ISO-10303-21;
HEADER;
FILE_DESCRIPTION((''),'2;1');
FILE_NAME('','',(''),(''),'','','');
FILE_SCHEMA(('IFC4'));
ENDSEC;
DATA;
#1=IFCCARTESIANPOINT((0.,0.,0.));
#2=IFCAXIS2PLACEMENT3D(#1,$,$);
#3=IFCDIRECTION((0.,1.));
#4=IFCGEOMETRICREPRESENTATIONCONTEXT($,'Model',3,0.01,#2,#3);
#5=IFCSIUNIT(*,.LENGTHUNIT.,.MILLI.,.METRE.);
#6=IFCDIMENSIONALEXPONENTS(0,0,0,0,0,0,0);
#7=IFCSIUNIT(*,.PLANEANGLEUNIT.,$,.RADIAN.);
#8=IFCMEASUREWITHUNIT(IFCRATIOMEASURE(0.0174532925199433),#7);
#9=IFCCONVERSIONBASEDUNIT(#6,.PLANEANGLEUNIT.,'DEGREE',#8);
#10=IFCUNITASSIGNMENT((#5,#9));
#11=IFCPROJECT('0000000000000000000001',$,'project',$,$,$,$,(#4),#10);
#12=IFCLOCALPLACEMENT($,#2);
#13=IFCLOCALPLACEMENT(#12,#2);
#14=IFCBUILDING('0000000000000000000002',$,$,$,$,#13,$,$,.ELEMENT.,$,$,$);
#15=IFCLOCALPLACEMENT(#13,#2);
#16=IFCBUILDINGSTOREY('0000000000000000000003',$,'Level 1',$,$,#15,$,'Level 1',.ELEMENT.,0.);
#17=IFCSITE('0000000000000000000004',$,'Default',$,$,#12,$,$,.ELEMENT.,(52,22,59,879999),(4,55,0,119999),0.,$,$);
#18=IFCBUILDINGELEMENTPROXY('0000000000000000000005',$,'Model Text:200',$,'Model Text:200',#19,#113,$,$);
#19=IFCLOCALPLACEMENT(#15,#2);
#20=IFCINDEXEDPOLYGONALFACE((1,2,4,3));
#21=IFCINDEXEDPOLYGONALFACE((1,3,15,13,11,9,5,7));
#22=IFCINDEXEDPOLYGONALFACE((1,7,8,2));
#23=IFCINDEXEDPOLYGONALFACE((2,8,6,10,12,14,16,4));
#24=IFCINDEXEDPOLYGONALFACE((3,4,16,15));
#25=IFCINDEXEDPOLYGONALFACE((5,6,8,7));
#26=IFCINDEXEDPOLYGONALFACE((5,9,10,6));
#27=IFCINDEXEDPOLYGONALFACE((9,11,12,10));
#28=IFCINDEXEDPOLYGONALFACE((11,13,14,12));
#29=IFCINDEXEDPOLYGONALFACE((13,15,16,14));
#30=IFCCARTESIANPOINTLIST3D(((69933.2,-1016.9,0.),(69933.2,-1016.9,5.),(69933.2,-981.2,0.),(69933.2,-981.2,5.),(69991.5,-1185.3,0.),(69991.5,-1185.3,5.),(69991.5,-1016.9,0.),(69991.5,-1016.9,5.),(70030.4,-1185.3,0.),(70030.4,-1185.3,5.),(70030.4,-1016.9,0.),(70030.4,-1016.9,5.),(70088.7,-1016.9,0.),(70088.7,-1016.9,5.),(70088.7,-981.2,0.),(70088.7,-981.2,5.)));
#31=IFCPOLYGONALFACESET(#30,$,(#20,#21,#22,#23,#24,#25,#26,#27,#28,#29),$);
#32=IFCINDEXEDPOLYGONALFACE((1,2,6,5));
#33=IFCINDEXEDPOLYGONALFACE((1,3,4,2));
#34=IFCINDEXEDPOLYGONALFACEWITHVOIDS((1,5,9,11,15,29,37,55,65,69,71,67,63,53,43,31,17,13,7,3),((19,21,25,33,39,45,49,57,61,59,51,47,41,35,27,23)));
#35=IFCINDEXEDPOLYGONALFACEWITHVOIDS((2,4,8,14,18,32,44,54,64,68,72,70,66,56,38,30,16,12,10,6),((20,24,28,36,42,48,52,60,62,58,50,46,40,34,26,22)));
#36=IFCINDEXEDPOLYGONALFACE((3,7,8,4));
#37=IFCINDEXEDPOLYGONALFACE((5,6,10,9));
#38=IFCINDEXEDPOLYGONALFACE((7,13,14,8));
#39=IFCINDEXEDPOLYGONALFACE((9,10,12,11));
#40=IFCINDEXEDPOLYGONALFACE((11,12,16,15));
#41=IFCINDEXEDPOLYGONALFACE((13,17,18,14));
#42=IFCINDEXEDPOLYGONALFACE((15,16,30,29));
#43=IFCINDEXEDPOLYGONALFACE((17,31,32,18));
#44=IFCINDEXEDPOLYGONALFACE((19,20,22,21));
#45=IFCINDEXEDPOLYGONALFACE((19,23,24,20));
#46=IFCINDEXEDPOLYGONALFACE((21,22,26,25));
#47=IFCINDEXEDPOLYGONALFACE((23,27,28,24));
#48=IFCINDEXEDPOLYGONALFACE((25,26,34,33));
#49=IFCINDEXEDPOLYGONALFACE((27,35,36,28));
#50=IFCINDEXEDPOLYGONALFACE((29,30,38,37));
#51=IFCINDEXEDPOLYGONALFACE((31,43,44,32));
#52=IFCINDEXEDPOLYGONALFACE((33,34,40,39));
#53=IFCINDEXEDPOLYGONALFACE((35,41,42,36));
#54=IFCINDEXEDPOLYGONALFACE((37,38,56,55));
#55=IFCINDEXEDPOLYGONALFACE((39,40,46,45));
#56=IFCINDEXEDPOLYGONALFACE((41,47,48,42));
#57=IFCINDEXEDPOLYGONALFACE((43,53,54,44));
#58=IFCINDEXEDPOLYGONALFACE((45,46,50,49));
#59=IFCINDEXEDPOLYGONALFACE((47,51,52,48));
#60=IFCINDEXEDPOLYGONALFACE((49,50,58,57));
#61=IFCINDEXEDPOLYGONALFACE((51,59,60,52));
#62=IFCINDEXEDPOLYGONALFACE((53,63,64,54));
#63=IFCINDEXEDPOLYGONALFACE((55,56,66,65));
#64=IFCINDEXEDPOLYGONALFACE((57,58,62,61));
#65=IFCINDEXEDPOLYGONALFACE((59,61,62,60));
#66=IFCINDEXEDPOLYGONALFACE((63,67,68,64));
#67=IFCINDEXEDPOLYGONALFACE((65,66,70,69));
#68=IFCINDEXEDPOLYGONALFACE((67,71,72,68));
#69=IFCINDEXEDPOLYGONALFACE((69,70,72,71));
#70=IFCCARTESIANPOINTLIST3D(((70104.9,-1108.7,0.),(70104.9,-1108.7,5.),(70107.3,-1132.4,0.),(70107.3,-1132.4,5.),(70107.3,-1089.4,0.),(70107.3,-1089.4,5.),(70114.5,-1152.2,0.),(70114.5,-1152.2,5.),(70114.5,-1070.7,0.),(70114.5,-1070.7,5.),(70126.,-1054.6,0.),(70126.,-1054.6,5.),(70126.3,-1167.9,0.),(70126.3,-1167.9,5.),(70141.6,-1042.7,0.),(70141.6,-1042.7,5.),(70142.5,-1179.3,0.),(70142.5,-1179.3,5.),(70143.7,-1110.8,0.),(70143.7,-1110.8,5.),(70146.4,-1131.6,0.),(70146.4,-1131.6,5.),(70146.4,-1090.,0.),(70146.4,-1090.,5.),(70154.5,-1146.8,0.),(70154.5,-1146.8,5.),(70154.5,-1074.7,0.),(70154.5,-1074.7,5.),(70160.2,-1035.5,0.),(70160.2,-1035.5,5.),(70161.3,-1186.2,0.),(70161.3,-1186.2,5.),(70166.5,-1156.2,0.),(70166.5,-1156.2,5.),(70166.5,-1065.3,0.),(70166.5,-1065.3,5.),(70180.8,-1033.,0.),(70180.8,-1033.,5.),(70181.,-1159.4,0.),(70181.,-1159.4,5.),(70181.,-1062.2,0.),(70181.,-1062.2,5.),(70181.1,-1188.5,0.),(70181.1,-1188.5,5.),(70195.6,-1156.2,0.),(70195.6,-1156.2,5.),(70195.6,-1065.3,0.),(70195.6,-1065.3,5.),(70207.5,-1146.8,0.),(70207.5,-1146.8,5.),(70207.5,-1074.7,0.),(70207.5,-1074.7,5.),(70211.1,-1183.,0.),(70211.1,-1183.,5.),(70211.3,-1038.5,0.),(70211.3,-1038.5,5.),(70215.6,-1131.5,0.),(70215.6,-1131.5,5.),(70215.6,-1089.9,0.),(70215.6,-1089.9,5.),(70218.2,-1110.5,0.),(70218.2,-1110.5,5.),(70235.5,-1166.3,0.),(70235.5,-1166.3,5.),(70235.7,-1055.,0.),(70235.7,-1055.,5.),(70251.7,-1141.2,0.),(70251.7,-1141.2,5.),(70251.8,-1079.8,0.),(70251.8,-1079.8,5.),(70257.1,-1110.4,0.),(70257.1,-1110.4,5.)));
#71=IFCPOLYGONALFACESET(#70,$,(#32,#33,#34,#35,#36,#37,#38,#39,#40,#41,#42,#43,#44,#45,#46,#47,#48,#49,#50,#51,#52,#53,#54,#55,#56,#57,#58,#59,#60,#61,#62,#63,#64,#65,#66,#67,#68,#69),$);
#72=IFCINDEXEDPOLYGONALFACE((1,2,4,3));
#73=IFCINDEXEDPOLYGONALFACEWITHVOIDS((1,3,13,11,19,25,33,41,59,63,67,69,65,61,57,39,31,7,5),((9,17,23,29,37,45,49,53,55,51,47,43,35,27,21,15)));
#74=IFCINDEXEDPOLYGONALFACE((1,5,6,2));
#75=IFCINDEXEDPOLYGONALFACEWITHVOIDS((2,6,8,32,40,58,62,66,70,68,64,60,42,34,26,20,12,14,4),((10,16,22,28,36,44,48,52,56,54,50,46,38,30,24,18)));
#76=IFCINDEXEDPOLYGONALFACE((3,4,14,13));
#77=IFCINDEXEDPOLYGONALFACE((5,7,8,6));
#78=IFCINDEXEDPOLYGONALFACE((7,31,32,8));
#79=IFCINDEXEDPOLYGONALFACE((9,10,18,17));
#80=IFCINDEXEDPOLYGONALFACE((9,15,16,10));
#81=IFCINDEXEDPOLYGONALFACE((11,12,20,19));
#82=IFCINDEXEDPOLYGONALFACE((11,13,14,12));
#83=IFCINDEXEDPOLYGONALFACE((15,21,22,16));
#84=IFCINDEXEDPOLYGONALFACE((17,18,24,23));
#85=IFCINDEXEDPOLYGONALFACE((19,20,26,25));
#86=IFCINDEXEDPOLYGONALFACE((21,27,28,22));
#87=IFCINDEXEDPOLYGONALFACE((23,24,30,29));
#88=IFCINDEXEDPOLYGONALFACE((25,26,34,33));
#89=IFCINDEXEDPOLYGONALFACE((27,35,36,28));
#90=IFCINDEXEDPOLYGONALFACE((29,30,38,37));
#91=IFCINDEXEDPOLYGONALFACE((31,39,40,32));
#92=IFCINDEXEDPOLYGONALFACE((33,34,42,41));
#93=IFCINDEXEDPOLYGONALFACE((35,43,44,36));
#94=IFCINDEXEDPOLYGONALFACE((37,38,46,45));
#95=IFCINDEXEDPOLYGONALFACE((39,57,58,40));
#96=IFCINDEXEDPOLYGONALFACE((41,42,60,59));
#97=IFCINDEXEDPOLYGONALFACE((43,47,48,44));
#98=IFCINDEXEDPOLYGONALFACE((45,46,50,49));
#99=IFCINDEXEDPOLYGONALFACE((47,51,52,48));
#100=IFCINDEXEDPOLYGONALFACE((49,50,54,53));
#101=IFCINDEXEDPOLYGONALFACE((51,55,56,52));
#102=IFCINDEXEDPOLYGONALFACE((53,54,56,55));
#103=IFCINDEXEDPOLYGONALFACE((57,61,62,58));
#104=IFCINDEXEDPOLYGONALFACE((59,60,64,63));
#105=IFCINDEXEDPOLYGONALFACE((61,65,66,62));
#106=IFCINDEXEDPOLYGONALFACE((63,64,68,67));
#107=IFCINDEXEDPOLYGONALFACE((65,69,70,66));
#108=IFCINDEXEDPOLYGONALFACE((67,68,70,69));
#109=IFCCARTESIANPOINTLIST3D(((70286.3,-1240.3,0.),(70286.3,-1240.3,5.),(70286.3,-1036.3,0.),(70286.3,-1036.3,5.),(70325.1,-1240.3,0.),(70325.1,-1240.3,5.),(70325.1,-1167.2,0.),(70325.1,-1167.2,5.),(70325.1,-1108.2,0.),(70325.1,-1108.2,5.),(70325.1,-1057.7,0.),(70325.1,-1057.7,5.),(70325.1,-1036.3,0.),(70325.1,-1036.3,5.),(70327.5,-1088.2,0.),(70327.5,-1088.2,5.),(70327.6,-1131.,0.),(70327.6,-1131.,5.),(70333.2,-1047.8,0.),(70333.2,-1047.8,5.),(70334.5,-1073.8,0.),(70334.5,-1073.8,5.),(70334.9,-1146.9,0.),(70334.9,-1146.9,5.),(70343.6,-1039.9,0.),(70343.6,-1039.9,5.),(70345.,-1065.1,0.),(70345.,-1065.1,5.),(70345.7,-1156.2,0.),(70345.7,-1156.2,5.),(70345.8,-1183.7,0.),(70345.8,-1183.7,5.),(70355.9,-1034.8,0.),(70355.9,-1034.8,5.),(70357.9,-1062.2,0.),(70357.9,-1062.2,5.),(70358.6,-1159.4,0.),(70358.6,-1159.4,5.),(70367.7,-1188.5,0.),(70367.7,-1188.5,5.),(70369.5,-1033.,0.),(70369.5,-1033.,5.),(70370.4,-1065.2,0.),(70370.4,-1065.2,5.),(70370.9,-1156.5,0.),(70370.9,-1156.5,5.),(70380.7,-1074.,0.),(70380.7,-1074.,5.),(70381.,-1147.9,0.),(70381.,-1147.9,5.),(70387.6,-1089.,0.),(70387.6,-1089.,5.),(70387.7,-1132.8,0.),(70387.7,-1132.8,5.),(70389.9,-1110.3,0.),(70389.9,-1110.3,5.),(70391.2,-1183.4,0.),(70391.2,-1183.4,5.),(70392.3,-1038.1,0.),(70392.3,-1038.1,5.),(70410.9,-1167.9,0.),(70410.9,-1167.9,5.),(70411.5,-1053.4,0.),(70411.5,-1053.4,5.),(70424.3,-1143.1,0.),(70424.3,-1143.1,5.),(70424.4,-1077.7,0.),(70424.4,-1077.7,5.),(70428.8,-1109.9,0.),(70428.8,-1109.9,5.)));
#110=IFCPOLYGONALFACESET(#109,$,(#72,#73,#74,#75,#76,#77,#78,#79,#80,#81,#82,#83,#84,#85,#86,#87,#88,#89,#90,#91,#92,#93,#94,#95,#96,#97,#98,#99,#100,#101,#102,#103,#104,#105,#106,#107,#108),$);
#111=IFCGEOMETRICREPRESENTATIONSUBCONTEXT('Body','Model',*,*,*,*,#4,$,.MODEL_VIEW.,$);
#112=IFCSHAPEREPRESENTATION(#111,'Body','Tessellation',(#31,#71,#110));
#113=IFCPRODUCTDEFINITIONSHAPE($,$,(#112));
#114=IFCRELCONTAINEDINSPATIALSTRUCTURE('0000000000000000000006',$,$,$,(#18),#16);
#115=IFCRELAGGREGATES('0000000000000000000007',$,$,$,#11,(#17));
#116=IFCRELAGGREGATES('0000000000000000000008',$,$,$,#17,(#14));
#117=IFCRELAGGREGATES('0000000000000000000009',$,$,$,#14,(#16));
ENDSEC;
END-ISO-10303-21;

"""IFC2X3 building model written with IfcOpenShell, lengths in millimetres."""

from ifc_helpers import new_model, entity, si_unit, converted_unit, direction, frame, origin, place, context, subcontext, project, spatial, polyline, outline, extrude, element, save


model = new_model("IFC2X3")

# Units and contexts
model_context = context("Model", 3, precision=0.01, world=origin(), true_north=direction((0.0, 1.0)))
body_context = subcontext(model_context, "Body", "Model", "MODEL_VIEW")
ifc_project = project(units=[si_unit("LENGTHUNIT", "METRE", prefix="MILLI"), converted_unit("PLANEANGLEUNIT", "DEGREE", entity("IfcRatioMeasure", 0.0174532925199433), si_unit("PLANEANGLEUNIT", "RADIAN"), dimensions=[0, 0, 0, 0, 0, 0, 0])], contexts=[model_context])

# Site, building, storey
site_placement = place(None, origin())
site = spatial("IfcSite", under=ifc_project, at=site_placement, Name="Default", CompositionType="ELEMENT", RefLatitude=(52, 22, 59, 879999), RefLongitude=(4, 55, 0, 119999), RefElevation=0.0)
building_placement = place(site_placement, origin())
building = spatial("IfcBuilding", under=site, at=building_placement, CompositionType="ELEMENT")
storey_placement = place(building_placement, origin())
storey = spatial("IfcBuildingStorey", under=building, at=storey_placement, Name="Level 1", LongName="Level 1", CompositionType="ELEMENT", Elevation=0.0)

# Building element proxy
proxy_1_placement = place(building_placement, origin())
element("IfcBuildingElementProxy", 1, at=proxy_1_placement, inside=storey, Name="Model Text:200", ObjectType="Model Text:200", context=body_context, shape_type="SweptSolid", body=[
    extrude(outline(polyline([(-19.4, -135.2), (19.4, -135.2), (19.4, 33.2), (77.7, 33.2), (77.7, 68.8), (-77.7, 68.8), (-77.7, 33.2), (-19.4, 33.2), (-19.4, -135.2)])), frame((70010.9, -1050.1, 0.0)), (0.0, 0.0, 1.0), 5.0),
    extrude(outline(polyline([(-8.8, -65.7), (15.1, -65.7), (35.5, -60.5), (52.3, -50.4), (65.3, -35.4), (74.1, -17.3), (78.4, 2.1), (75.9, 32.5), (61.8, 58.5), (38.4, 77.1), (8.3, 85.6), (-22.7, 83.3), (-49.0, 69.9), (-67.8, 47.3), (-76.3, 17.5), (-76.0, -3.3), (-70.7, -22.5), (-60.5, -39.2), (-45.5, -52.3), (-27.7, -61.4), (-8.8, -65.7)]), holes=[polyline([(-2.7, -27.2), (-23.1, -22.5), (-37.5, -12.9), (-45.7, 0.0), (-47.3, 14.8), (-42.7, 28.9), (-32.2, 39.9), (-16.3, 46.3), (4.5, 46.9), (25.1, 42.1), (39.6, 32.6), (47.7, 19.7), (49.4, 5.0), (44.8, -9.2), (34.2, -20.2), (18.2, -26.7), (-2.7, -27.2)])]), frame((70171.1, -1110.8, 0.0), z_axis=(0.0, 0.0, 1.0), x_axis=(0.100608, -0.994926, 0.0)), (0.0, 0.0, 1.0), 5.0),
    extrude(outline(polyline([(-73.1, -75.4), (130.9, -75.4), (130.9, -36.6), (57.8, -36.6), (74.3, -15.9), (79.1, 6.0), (73.9, 29.5), (58.4, 49.2), (33.6, 62.6), (0.5, 67.1), (-31.8, 62.8), (-56.1, 49.8), (-71.3, 30.7), (-76.4, 7.8), (-74.7, -5.8), (-69.6, -18.1), (-61.7, -28.5), (-51.7, -36.6), (-73.1, -36.6), (-73.1, -75.4)]), holes=[polyline([(-1.2, -36.6), (-21.2, -34.2), (-35.6, -27.2), (-44.3, -16.7), (-47.2, -3.8), (-44.3, 8.7), (-35.4, 19.0), (-20.4, 25.9), (0.8, 28.2), (23.3, 26.0), (38.5, 19.3), (47.1, 9.2), (49.9, -3.1), (46.8, -16.0), (37.4, -26.8), (21.5, -34.1), (-1.2, -36.6)])]), frame((70361.7, -1109.4, 0.0), z_axis=(0.0, 0.0, 1.0), x_axis=(0.0, -1.0, 0.0)), (0.0, 0.0, 1.0), 5.0),
])

save(model, "model.ifc")
